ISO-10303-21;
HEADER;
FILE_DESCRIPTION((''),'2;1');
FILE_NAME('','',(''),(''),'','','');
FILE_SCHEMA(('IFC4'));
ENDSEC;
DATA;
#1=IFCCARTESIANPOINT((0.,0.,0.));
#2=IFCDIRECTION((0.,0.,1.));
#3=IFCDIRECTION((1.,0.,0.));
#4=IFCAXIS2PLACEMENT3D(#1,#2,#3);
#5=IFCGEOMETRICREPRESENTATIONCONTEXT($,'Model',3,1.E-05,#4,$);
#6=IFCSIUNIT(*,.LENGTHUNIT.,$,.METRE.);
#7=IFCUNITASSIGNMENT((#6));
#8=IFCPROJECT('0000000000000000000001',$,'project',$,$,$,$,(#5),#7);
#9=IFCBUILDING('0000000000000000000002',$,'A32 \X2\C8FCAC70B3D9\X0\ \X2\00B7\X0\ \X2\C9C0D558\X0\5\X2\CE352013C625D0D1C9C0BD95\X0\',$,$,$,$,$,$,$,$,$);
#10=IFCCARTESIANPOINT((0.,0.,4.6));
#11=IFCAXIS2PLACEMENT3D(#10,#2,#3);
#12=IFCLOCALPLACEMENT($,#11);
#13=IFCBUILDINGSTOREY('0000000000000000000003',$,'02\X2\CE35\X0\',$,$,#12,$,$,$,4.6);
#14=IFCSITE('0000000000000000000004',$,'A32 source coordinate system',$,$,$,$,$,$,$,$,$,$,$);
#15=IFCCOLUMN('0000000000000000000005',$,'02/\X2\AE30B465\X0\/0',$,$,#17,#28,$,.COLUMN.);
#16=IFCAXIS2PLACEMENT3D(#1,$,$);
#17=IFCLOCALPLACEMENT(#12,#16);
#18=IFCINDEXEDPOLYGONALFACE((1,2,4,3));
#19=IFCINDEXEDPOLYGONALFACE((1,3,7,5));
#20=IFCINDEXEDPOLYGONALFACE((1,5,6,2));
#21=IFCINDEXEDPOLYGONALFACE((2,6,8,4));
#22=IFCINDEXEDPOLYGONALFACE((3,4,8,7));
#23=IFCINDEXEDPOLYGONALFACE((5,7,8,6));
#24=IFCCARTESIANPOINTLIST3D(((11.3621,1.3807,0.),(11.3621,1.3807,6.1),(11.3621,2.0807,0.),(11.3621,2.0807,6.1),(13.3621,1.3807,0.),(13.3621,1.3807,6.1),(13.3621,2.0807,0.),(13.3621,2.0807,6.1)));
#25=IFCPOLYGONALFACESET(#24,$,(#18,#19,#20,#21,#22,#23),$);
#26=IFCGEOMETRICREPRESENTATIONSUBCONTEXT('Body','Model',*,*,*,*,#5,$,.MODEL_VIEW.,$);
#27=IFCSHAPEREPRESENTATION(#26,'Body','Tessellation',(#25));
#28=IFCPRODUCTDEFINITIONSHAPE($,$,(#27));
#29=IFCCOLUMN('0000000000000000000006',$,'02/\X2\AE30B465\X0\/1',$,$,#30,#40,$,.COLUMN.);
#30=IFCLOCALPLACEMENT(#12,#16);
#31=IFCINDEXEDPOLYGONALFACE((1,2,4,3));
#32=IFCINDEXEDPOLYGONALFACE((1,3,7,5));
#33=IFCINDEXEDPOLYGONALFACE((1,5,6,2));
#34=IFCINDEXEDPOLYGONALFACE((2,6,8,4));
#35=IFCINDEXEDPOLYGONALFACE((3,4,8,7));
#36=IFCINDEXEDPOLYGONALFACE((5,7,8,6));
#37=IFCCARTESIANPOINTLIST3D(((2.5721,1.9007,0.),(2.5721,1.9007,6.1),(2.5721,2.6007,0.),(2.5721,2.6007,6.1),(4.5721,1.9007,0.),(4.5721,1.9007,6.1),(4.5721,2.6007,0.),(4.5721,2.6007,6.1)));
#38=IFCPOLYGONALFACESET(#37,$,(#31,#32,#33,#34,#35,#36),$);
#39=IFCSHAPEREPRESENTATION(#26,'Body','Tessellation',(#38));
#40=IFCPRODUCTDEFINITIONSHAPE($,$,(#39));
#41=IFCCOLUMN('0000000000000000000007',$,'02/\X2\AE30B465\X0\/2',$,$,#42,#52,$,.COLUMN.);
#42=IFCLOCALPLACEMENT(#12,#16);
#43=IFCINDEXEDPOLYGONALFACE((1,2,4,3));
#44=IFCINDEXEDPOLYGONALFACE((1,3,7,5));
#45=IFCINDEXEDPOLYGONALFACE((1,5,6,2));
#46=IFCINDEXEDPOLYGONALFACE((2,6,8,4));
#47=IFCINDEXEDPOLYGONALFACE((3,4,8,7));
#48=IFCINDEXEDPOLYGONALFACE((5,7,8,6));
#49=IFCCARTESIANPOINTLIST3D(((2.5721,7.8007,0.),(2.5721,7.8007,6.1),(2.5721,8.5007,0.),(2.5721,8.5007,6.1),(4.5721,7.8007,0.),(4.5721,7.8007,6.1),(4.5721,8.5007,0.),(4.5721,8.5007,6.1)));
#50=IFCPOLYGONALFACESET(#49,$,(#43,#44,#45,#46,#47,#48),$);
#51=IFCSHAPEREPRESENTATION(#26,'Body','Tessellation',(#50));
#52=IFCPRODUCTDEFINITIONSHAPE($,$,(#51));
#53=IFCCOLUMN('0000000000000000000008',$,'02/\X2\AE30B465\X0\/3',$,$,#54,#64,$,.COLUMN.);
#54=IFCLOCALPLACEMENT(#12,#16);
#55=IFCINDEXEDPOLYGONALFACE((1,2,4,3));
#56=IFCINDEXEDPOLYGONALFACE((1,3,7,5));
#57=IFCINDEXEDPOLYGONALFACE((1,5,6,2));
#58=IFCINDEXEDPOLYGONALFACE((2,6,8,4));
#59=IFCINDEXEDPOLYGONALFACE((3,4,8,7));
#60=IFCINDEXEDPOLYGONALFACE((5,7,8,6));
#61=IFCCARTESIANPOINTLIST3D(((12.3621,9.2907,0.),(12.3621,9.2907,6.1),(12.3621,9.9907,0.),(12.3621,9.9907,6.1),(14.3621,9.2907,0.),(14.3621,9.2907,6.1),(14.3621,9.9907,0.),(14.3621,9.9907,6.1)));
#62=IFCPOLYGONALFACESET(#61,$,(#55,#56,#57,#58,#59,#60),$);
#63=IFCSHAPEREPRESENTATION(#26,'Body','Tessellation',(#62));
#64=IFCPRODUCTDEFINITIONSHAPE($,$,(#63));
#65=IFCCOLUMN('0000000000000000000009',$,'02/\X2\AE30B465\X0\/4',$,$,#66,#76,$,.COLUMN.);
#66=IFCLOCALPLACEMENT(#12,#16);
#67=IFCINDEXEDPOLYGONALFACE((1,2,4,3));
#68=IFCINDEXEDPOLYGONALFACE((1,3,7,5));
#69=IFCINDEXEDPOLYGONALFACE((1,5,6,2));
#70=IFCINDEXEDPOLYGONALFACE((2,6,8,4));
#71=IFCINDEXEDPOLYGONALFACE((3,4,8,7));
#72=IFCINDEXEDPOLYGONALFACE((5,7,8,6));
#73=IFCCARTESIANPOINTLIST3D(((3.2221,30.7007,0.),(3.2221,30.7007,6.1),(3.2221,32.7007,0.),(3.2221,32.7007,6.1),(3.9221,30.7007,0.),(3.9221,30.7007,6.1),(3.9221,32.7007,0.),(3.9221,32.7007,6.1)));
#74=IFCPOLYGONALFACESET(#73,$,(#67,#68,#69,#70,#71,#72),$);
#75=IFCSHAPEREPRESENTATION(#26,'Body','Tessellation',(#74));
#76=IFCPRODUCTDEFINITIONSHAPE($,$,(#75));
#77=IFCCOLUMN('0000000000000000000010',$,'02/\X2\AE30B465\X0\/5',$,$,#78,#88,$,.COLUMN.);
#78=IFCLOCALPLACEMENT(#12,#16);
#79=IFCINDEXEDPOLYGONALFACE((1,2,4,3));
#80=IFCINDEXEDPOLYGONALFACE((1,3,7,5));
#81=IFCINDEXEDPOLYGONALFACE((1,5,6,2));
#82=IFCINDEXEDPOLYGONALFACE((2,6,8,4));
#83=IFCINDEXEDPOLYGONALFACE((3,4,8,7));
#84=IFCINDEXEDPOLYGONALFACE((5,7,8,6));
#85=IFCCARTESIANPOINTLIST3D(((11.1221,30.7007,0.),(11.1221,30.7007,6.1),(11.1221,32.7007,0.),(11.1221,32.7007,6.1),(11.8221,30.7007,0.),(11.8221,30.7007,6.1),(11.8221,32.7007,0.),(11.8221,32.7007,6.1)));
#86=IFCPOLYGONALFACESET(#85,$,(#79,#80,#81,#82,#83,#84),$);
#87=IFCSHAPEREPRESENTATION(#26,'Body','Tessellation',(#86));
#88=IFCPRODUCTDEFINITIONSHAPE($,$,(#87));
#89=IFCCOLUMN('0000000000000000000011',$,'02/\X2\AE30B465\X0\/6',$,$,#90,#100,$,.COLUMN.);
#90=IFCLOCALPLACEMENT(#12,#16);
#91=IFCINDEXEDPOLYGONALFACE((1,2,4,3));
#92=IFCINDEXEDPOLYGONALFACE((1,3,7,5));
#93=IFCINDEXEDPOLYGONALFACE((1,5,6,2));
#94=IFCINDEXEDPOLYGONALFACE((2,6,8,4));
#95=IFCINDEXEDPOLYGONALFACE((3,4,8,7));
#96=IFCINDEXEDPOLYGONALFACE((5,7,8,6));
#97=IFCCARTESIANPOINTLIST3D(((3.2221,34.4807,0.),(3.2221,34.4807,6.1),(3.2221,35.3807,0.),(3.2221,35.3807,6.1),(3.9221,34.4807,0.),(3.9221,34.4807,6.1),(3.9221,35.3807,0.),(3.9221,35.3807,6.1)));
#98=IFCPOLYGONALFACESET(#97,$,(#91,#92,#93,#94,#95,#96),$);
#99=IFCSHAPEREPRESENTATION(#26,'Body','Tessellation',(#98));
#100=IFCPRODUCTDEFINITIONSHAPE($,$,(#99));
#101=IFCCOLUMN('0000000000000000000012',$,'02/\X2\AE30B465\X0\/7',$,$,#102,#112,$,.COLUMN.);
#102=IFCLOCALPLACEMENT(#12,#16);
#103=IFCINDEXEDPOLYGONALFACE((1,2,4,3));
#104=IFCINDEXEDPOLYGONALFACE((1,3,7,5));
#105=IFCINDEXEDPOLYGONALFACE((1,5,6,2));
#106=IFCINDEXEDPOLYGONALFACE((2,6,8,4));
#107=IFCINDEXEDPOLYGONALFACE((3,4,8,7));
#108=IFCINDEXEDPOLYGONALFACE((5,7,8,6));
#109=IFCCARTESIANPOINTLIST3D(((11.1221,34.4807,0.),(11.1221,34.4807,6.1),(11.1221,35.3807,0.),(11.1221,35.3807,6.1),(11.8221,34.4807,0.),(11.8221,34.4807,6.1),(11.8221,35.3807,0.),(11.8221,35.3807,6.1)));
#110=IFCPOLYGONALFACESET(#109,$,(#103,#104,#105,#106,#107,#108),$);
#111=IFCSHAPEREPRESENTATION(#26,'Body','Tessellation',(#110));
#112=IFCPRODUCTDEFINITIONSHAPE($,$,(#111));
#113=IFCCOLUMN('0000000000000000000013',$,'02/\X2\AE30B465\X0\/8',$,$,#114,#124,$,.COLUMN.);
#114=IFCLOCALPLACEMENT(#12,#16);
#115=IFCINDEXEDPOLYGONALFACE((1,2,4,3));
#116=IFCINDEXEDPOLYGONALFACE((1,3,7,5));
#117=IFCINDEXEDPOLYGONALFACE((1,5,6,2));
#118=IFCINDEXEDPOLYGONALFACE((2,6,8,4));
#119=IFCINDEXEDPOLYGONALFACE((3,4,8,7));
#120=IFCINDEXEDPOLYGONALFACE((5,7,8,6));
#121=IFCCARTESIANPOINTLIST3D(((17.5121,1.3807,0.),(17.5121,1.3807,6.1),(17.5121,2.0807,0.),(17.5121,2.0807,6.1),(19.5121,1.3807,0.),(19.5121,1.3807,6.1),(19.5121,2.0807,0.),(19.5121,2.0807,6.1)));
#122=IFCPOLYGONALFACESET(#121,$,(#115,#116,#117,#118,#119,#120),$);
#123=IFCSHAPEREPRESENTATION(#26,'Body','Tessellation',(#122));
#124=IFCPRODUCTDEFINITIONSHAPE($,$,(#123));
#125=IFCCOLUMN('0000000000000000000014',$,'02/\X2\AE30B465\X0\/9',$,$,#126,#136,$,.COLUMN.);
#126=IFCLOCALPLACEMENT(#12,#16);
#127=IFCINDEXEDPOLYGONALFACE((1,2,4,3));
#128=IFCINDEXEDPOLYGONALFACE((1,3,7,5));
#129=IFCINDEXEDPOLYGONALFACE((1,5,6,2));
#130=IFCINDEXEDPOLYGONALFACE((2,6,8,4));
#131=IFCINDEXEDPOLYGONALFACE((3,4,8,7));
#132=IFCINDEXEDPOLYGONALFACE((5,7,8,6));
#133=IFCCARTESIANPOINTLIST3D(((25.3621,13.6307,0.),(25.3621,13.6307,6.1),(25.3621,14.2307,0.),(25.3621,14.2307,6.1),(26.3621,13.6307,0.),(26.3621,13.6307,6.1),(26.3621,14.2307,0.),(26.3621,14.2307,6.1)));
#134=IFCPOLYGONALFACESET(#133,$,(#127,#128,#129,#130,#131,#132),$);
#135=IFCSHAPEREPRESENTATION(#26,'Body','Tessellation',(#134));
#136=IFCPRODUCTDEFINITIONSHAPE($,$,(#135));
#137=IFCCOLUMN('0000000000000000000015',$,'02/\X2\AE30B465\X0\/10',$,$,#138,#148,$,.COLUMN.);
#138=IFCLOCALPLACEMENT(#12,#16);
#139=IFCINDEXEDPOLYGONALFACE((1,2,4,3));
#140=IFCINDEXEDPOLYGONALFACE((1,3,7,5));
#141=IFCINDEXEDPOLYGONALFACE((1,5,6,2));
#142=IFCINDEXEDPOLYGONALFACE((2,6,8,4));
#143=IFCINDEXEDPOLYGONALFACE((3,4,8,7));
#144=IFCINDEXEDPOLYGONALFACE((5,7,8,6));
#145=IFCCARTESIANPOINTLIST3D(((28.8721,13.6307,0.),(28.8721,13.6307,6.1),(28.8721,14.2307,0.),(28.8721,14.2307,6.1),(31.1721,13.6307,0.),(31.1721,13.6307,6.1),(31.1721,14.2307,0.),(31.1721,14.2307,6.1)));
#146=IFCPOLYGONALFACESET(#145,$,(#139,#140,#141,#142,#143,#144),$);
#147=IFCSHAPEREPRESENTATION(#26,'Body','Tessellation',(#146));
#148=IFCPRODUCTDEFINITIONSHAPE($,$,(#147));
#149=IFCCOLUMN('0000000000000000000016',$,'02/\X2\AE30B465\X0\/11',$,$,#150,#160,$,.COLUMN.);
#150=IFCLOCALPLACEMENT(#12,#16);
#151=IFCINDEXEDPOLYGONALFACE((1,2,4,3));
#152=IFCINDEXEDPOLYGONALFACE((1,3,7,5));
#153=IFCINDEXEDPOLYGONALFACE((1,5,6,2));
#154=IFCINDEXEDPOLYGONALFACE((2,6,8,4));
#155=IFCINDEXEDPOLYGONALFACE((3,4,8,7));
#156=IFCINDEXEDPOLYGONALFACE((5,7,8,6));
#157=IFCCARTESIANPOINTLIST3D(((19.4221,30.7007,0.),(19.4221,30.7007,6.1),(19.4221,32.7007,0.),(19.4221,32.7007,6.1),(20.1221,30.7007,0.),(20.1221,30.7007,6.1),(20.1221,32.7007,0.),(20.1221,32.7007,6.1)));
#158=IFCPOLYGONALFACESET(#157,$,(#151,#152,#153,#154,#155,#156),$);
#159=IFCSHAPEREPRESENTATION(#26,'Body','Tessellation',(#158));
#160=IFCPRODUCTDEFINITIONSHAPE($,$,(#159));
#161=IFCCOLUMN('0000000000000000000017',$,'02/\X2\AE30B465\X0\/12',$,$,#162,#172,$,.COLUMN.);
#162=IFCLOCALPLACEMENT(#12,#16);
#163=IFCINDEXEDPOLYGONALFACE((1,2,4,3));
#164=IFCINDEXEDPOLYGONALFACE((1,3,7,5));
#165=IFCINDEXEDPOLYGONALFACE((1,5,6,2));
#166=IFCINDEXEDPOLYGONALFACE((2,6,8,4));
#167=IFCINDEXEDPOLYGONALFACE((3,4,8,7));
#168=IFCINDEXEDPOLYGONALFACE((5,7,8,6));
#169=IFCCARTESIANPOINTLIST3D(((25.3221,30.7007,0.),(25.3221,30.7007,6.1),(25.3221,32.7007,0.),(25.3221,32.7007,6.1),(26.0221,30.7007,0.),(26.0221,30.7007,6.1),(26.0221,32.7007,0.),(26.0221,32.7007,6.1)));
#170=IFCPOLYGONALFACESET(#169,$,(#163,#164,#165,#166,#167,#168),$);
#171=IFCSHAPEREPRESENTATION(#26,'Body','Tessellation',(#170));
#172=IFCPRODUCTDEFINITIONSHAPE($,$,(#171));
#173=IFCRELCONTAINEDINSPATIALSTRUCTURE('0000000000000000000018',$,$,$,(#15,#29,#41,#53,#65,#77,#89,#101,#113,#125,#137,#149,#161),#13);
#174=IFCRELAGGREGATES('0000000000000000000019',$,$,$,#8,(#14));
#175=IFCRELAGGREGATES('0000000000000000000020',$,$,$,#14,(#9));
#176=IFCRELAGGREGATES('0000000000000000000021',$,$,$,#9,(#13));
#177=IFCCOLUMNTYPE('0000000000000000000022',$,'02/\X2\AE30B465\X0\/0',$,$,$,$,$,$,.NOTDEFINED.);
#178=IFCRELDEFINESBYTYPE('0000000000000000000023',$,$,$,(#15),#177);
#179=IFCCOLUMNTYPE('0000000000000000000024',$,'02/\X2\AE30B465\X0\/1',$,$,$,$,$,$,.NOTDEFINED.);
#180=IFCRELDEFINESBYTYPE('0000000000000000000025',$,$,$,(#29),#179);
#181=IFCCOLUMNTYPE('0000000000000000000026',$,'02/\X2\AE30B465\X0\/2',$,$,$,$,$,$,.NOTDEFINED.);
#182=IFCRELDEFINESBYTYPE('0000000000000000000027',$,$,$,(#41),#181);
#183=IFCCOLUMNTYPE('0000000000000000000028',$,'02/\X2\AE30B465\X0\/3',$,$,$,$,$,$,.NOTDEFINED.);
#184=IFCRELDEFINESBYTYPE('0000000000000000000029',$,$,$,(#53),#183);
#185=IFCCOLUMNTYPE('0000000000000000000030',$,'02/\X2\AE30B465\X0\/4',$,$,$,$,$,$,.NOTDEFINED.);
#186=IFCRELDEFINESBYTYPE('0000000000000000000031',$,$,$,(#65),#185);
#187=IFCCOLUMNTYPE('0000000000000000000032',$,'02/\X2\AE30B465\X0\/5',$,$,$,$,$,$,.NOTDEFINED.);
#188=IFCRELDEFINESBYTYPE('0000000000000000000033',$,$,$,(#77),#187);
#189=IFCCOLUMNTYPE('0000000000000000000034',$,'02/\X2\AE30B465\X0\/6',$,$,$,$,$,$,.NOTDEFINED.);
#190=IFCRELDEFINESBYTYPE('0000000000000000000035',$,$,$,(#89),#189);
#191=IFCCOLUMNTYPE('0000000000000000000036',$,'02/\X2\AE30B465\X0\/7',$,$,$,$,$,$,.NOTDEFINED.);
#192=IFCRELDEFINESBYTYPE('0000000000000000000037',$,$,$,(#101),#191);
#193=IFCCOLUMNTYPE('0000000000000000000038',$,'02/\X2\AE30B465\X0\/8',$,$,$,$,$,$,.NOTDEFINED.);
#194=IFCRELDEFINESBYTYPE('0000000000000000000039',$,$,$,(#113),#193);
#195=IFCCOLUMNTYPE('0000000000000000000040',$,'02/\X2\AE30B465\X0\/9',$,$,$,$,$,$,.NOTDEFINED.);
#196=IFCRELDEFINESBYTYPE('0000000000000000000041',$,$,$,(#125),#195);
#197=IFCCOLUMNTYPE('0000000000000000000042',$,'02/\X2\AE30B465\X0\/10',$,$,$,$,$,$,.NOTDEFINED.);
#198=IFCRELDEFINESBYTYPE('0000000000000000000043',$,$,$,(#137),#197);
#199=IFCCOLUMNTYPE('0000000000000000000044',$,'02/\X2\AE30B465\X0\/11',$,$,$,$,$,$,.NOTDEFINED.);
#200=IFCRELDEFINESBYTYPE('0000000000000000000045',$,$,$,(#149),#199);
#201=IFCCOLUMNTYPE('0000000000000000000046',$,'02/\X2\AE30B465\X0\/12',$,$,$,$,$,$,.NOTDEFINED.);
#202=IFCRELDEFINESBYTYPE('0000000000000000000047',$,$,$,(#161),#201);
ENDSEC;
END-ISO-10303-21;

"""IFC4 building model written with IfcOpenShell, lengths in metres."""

from ifc_helpers import new_model, si_unit, frame, origin, origin_with_axes, place, context, subcontext, project, spatial, polyline, outline, extrude, source, transform, mapped, type_object, type_shapes, element, save


model = new_model("IFC4")

# Units and contexts
model_context = context("Model", 3, precision=1e-05, world=origin_with_axes())
body_context = subcontext(model_context, "Body", "Model", "MODEL_VIEW")
ifc_project = project(units=[si_unit("LENGTHUNIT", "METRE")], contexts=[model_context])

# Site, building, storey
site = spatial("IfcSite", under=ifc_project, Name="A32 source coordinate system")
building = spatial("IfcBuilding", under=site, Name="A32 주거동 · 지하5층–옥탑지붕")
storey_placement = place(None, frame((0.0, 0.0, 4.6), z_axis=(0.0, 0.0, 1.0), x_axis=(1.0, 0.0, 0.0)))
storey = spatial("IfcBuildingStorey", under=building, at=storey_placement, Name="02층", Elevation=4.6)

# Columns
column_type_1 = type_object("IfcColumnType", Name="02/기둥/0", PredefinedType="NOTDEFINED")
shared_shape_1 = source(origin(), body_context, "Body", "SweptSolid", [
    extrude(outline(polyline([(11.3621, 2.0807), (13.3621, 2.0807), (13.3621, 1.3807), (11.3621, 1.3807), (11.3621, 2.0807)])), origin(), (0.0, 0.0, 1.0), 6.1),
])
type_shapes(column_type_1, [shared_shape_1])
column_1_placement = place(storey_placement, origin_with_axes())
element("IfcColumn", 1, at=column_1_placement, inside=storey, type_object=column_type_1, Name="02/기둥/0", PredefinedType="COLUMN", context=body_context, shape_type="MappedRepresentation", body=[
    mapped(shared_shape_1, transform((0.0, 0.0, 0.0), scale=1.0)),
])
column_type_2 = type_object("IfcColumnType", Name="02/기둥/1", PredefinedType="NOTDEFINED")
shared_shape_2 = source(origin(), body_context, "Body", "SweptSolid", [
    extrude(outline(polyline([(2.5721, 2.6007), (4.5721, 2.6007), (4.5721, 1.9007), (2.5721, 1.9007), (2.5721, 2.6007)])), origin(), (0.0, 0.0, 1.0), 6.1),
])
type_shapes(column_type_2, [shared_shape_2])
column_2_placement = place(storey_placement, origin_with_axes())
element("IfcColumn", 2, at=column_2_placement, inside=storey, type_object=column_type_2, Name="02/기둥/1", PredefinedType="COLUMN", context=body_context, shape_type="MappedRepresentation", body=[
    mapped(shared_shape_2, transform((0.0, 0.0, 0.0), scale=1.0)),
])
column_type_3 = type_object("IfcColumnType", Name="02/기둥/2", PredefinedType="NOTDEFINED")
shared_shape_3 = source(origin(), body_context, "Body", "SweptSolid", [
    extrude(outline(polyline([(4.5721, 8.5007), (4.5721, 7.8007), (2.5721, 7.8007), (2.5721, 8.5007), (4.5721, 8.5007)])), origin(), (0.0, 0.0, 1.0), 6.1),
])
type_shapes(column_type_3, [shared_shape_3])
column_3_placement = place(storey_placement, origin_with_axes())
element("IfcColumn", 3, at=column_3_placement, inside=storey, type_object=column_type_3, Name="02/기둥/2", PredefinedType="COLUMN", context=body_context, shape_type="MappedRepresentation", body=[
    mapped(shared_shape_3, transform((0.0, 0.0, 0.0), scale=1.0)),
])
column_type_4 = type_object("IfcColumnType", Name="02/기둥/3", PredefinedType="NOTDEFINED")
shared_shape_4 = source(origin(), body_context, "Body", "SweptSolid", [
    extrude(outline(polyline([(14.3621, 9.9907), (14.3621, 9.2907), (12.3621, 9.2907), (12.3621, 9.9907), (14.3621, 9.9907)])), origin(), (0.0, 0.0, 1.0), 6.1),
])
type_shapes(column_type_4, [shared_shape_4])
column_4_placement = place(storey_placement, origin_with_axes())
element("IfcColumn", 4, at=column_4_placement, inside=storey, type_object=column_type_4, Name="02/기둥/3", PredefinedType="COLUMN", context=body_context, shape_type="MappedRepresentation", body=[
    mapped(shared_shape_4, transform((0.0, 0.0, 0.0), scale=1.0)),
])
column_type_5 = type_object("IfcColumnType", Name="02/기둥/4", PredefinedType="NOTDEFINED")
shared_shape_5 = source(origin(), body_context, "Body", "SweptSolid", [
    extrude(outline(polyline([(3.2221, 32.7007), (3.9221, 32.7007), (3.9221, 30.7007), (3.2221, 30.7007), (3.2221, 32.7007)])), origin(), (0.0, 0.0, 1.0), 6.1),
])
type_shapes(column_type_5, [shared_shape_5])
column_5_placement = place(storey_placement, origin_with_axes())
element("IfcColumn", 5, at=column_5_placement, inside=storey, type_object=column_type_5, Name="02/기둥/4", PredefinedType="COLUMN", context=body_context, shape_type="MappedRepresentation", body=[
    mapped(shared_shape_5, transform((0.0, 0.0, 0.0), scale=1.0)),
])
column_type_6 = type_object("IfcColumnType", Name="02/기둥/5", PredefinedType="NOTDEFINED")
shared_shape_6 = source(origin(), body_context, "Body", "SweptSolid", [
    extrude(outline(polyline([(11.1221, 32.7007), (11.8221, 32.7007), (11.8221, 30.7007), (11.1221, 30.7007), (11.1221, 32.7007)])), origin(), (0.0, 0.0, 1.0), 6.1),
])
type_shapes(column_type_6, [shared_shape_6])
column_6_placement = place(storey_placement, origin_with_axes())
element("IfcColumn", 6, at=column_6_placement, inside=storey, type_object=column_type_6, Name="02/기둥/5", PredefinedType="COLUMN", context=body_context, shape_type="MappedRepresentation", body=[
    mapped(shared_shape_6, transform((0.0, 0.0, 0.0), scale=1.0)),
])
column_type_7 = type_object("IfcColumnType", Name="02/기둥/6", PredefinedType="NOTDEFINED")
shared_shape_7 = source(origin(), body_context, "Body", "SweptSolid", [
    extrude(outline(polyline([(3.2221, 34.4807), (3.2221, 35.3807), (3.9221, 35.3807), (3.9221, 34.4807), (3.2221, 34.4807)])), origin(), (0.0, 0.0, 1.0), 6.1),
])
type_shapes(column_type_7, [shared_shape_7])
column_7_placement = place(storey_placement, origin_with_axes())
element("IfcColumn", 7, at=column_7_placement, inside=storey, type_object=column_type_7, Name="02/기둥/6", PredefinedType="COLUMN", context=body_context, shape_type="MappedRepresentation", body=[
    mapped(shared_shape_7, transform((0.0, 0.0, 0.0), scale=1.0)),
])
column_type_8 = type_object("IfcColumnType", Name="02/기둥/7", PredefinedType="NOTDEFINED")
shared_shape_8 = source(origin(), body_context, "Body", "SweptSolid", [
    extrude(outline(polyline([(11.1221, 34.4807), (11.1221, 35.3807), (11.8221, 35.3807), (11.8221, 34.4807), (11.1221, 34.4807)])), origin(), (0.0, 0.0, 1.0), 6.1),
])
type_shapes(column_type_8, [shared_shape_8])
column_8_placement = place(storey_placement, origin_with_axes())
element("IfcColumn", 8, at=column_8_placement, inside=storey, type_object=column_type_8, Name="02/기둥/7", PredefinedType="COLUMN", context=body_context, shape_type="MappedRepresentation", body=[
    mapped(shared_shape_8, transform((0.0, 0.0, 0.0), scale=1.0)),
])
column_type_9 = type_object("IfcColumnType", Name="02/기둥/8", PredefinedType="NOTDEFINED")
shared_shape_9 = source(origin(), body_context, "Body", "SweptSolid", [
    extrude(outline(polyline([(19.5121, 2.0807), (19.5121, 1.3807), (17.5121, 1.3807), (17.5121, 2.0807), (19.5121, 2.0807)])), origin(), (0.0, 0.0, 1.0), 6.1),
])
type_shapes(column_type_9, [shared_shape_9])
column_9_placement = place(storey_placement, origin_with_axes())
element("IfcColumn", 9, at=column_9_placement, inside=storey, type_object=column_type_9, Name="02/기둥/8", PredefinedType="COLUMN", context=body_context, shape_type="MappedRepresentation", body=[
    mapped(shared_shape_9, transform((0.0, 0.0, 0.0), scale=1.0)),
])
column_type_10 = type_object("IfcColumnType", Name="02/기둥/9", PredefinedType="NOTDEFINED")
shared_shape_10 = source(origin(), body_context, "Body", "SweptSolid", [
    extrude(outline(polyline([(25.3621, 14.2307), (26.3621, 14.2307), (26.3621, 13.6307), (25.3621, 13.6307), (25.3621, 14.2307)])), origin(), (0.0, 0.0, 1.0), 6.1),
])
type_shapes(column_type_10, [shared_shape_10])
column_10_placement = place(storey_placement, origin_with_axes())
element("IfcColumn", 10, at=column_10_placement, inside=storey, type_object=column_type_10, Name="02/기둥/9", PredefinedType="COLUMN", context=body_context, shape_type="MappedRepresentation", body=[
    mapped(shared_shape_10, transform((0.0, 0.0, 0.0), scale=1.0)),
])
column_type_11 = type_object("IfcColumnType", Name="02/기둥/10", PredefinedType="NOTDEFINED")
shared_shape_11 = source(origin(), body_context, "Body", "SweptSolid", [
    extrude(outline(polyline([(31.1721, 14.2307), (31.1721, 13.6307), (28.8721, 13.6307), (28.8721, 14.2307), (31.1721, 14.2307)])), origin(), (0.0, 0.0, 1.0), 6.1),
])
type_shapes(column_type_11, [shared_shape_11])
column_11_placement = place(storey_placement, origin_with_axes())
element("IfcColumn", 11, at=column_11_placement, inside=storey, type_object=column_type_11, Name="02/기둥/10", PredefinedType="COLUMN", context=body_context, shape_type="MappedRepresentation", body=[
    mapped(shared_shape_11, transform((0.0, 0.0, 0.0), scale=1.0)),
])
column_type_12 = type_object("IfcColumnType", Name="02/기둥/11", PredefinedType="NOTDEFINED")
shared_shape_12 = source(origin(), body_context, "Body", "SweptSolid", [
    extrude(outline(polyline([(19.4221, 30.7007), (19.4221, 32.7007), (20.1221, 32.7007), (20.1221, 30.7007), (19.4221, 30.7007)])), origin(), (0.0, 0.0, 1.0), 6.1),
])
type_shapes(column_type_12, [shared_shape_12])
column_12_placement = place(storey_placement, origin_with_axes())
element("IfcColumn", 12, at=column_12_placement, inside=storey, type_object=column_type_12, Name="02/기둥/11", PredefinedType="COLUMN", context=body_context, shape_type="MappedRepresentation", body=[
    mapped(shared_shape_12, transform((0.0, 0.0, 0.0), scale=1.0)),
])
column_type_13 = type_object("IfcColumnType", Name="02/기둥/12", PredefinedType="NOTDEFINED")
shared_shape_13 = source(origin(), body_context, "Body", "SweptSolid", [
    extrude(outline(polyline([(25.3221, 30.7007), (25.3221, 32.7007), (26.0221, 32.7007), (26.0221, 30.7007), (25.3221, 30.7007)])), origin(), (0.0, 0.0, 1.0), 6.1),
])
type_shapes(column_type_13, [shared_shape_13])
column_13_placement = place(storey_placement, origin_with_axes())
element("IfcColumn", 13, at=column_13_placement, inside=storey, type_object=column_type_13, Name="02/기둥/12", PredefinedType="COLUMN", context=body_context, shape_type="MappedRepresentation", body=[
    mapped(shared_shape_13, transform((0.0, 0.0, 0.0), scale=1.0)),
])

save(model, "model.ifc")
